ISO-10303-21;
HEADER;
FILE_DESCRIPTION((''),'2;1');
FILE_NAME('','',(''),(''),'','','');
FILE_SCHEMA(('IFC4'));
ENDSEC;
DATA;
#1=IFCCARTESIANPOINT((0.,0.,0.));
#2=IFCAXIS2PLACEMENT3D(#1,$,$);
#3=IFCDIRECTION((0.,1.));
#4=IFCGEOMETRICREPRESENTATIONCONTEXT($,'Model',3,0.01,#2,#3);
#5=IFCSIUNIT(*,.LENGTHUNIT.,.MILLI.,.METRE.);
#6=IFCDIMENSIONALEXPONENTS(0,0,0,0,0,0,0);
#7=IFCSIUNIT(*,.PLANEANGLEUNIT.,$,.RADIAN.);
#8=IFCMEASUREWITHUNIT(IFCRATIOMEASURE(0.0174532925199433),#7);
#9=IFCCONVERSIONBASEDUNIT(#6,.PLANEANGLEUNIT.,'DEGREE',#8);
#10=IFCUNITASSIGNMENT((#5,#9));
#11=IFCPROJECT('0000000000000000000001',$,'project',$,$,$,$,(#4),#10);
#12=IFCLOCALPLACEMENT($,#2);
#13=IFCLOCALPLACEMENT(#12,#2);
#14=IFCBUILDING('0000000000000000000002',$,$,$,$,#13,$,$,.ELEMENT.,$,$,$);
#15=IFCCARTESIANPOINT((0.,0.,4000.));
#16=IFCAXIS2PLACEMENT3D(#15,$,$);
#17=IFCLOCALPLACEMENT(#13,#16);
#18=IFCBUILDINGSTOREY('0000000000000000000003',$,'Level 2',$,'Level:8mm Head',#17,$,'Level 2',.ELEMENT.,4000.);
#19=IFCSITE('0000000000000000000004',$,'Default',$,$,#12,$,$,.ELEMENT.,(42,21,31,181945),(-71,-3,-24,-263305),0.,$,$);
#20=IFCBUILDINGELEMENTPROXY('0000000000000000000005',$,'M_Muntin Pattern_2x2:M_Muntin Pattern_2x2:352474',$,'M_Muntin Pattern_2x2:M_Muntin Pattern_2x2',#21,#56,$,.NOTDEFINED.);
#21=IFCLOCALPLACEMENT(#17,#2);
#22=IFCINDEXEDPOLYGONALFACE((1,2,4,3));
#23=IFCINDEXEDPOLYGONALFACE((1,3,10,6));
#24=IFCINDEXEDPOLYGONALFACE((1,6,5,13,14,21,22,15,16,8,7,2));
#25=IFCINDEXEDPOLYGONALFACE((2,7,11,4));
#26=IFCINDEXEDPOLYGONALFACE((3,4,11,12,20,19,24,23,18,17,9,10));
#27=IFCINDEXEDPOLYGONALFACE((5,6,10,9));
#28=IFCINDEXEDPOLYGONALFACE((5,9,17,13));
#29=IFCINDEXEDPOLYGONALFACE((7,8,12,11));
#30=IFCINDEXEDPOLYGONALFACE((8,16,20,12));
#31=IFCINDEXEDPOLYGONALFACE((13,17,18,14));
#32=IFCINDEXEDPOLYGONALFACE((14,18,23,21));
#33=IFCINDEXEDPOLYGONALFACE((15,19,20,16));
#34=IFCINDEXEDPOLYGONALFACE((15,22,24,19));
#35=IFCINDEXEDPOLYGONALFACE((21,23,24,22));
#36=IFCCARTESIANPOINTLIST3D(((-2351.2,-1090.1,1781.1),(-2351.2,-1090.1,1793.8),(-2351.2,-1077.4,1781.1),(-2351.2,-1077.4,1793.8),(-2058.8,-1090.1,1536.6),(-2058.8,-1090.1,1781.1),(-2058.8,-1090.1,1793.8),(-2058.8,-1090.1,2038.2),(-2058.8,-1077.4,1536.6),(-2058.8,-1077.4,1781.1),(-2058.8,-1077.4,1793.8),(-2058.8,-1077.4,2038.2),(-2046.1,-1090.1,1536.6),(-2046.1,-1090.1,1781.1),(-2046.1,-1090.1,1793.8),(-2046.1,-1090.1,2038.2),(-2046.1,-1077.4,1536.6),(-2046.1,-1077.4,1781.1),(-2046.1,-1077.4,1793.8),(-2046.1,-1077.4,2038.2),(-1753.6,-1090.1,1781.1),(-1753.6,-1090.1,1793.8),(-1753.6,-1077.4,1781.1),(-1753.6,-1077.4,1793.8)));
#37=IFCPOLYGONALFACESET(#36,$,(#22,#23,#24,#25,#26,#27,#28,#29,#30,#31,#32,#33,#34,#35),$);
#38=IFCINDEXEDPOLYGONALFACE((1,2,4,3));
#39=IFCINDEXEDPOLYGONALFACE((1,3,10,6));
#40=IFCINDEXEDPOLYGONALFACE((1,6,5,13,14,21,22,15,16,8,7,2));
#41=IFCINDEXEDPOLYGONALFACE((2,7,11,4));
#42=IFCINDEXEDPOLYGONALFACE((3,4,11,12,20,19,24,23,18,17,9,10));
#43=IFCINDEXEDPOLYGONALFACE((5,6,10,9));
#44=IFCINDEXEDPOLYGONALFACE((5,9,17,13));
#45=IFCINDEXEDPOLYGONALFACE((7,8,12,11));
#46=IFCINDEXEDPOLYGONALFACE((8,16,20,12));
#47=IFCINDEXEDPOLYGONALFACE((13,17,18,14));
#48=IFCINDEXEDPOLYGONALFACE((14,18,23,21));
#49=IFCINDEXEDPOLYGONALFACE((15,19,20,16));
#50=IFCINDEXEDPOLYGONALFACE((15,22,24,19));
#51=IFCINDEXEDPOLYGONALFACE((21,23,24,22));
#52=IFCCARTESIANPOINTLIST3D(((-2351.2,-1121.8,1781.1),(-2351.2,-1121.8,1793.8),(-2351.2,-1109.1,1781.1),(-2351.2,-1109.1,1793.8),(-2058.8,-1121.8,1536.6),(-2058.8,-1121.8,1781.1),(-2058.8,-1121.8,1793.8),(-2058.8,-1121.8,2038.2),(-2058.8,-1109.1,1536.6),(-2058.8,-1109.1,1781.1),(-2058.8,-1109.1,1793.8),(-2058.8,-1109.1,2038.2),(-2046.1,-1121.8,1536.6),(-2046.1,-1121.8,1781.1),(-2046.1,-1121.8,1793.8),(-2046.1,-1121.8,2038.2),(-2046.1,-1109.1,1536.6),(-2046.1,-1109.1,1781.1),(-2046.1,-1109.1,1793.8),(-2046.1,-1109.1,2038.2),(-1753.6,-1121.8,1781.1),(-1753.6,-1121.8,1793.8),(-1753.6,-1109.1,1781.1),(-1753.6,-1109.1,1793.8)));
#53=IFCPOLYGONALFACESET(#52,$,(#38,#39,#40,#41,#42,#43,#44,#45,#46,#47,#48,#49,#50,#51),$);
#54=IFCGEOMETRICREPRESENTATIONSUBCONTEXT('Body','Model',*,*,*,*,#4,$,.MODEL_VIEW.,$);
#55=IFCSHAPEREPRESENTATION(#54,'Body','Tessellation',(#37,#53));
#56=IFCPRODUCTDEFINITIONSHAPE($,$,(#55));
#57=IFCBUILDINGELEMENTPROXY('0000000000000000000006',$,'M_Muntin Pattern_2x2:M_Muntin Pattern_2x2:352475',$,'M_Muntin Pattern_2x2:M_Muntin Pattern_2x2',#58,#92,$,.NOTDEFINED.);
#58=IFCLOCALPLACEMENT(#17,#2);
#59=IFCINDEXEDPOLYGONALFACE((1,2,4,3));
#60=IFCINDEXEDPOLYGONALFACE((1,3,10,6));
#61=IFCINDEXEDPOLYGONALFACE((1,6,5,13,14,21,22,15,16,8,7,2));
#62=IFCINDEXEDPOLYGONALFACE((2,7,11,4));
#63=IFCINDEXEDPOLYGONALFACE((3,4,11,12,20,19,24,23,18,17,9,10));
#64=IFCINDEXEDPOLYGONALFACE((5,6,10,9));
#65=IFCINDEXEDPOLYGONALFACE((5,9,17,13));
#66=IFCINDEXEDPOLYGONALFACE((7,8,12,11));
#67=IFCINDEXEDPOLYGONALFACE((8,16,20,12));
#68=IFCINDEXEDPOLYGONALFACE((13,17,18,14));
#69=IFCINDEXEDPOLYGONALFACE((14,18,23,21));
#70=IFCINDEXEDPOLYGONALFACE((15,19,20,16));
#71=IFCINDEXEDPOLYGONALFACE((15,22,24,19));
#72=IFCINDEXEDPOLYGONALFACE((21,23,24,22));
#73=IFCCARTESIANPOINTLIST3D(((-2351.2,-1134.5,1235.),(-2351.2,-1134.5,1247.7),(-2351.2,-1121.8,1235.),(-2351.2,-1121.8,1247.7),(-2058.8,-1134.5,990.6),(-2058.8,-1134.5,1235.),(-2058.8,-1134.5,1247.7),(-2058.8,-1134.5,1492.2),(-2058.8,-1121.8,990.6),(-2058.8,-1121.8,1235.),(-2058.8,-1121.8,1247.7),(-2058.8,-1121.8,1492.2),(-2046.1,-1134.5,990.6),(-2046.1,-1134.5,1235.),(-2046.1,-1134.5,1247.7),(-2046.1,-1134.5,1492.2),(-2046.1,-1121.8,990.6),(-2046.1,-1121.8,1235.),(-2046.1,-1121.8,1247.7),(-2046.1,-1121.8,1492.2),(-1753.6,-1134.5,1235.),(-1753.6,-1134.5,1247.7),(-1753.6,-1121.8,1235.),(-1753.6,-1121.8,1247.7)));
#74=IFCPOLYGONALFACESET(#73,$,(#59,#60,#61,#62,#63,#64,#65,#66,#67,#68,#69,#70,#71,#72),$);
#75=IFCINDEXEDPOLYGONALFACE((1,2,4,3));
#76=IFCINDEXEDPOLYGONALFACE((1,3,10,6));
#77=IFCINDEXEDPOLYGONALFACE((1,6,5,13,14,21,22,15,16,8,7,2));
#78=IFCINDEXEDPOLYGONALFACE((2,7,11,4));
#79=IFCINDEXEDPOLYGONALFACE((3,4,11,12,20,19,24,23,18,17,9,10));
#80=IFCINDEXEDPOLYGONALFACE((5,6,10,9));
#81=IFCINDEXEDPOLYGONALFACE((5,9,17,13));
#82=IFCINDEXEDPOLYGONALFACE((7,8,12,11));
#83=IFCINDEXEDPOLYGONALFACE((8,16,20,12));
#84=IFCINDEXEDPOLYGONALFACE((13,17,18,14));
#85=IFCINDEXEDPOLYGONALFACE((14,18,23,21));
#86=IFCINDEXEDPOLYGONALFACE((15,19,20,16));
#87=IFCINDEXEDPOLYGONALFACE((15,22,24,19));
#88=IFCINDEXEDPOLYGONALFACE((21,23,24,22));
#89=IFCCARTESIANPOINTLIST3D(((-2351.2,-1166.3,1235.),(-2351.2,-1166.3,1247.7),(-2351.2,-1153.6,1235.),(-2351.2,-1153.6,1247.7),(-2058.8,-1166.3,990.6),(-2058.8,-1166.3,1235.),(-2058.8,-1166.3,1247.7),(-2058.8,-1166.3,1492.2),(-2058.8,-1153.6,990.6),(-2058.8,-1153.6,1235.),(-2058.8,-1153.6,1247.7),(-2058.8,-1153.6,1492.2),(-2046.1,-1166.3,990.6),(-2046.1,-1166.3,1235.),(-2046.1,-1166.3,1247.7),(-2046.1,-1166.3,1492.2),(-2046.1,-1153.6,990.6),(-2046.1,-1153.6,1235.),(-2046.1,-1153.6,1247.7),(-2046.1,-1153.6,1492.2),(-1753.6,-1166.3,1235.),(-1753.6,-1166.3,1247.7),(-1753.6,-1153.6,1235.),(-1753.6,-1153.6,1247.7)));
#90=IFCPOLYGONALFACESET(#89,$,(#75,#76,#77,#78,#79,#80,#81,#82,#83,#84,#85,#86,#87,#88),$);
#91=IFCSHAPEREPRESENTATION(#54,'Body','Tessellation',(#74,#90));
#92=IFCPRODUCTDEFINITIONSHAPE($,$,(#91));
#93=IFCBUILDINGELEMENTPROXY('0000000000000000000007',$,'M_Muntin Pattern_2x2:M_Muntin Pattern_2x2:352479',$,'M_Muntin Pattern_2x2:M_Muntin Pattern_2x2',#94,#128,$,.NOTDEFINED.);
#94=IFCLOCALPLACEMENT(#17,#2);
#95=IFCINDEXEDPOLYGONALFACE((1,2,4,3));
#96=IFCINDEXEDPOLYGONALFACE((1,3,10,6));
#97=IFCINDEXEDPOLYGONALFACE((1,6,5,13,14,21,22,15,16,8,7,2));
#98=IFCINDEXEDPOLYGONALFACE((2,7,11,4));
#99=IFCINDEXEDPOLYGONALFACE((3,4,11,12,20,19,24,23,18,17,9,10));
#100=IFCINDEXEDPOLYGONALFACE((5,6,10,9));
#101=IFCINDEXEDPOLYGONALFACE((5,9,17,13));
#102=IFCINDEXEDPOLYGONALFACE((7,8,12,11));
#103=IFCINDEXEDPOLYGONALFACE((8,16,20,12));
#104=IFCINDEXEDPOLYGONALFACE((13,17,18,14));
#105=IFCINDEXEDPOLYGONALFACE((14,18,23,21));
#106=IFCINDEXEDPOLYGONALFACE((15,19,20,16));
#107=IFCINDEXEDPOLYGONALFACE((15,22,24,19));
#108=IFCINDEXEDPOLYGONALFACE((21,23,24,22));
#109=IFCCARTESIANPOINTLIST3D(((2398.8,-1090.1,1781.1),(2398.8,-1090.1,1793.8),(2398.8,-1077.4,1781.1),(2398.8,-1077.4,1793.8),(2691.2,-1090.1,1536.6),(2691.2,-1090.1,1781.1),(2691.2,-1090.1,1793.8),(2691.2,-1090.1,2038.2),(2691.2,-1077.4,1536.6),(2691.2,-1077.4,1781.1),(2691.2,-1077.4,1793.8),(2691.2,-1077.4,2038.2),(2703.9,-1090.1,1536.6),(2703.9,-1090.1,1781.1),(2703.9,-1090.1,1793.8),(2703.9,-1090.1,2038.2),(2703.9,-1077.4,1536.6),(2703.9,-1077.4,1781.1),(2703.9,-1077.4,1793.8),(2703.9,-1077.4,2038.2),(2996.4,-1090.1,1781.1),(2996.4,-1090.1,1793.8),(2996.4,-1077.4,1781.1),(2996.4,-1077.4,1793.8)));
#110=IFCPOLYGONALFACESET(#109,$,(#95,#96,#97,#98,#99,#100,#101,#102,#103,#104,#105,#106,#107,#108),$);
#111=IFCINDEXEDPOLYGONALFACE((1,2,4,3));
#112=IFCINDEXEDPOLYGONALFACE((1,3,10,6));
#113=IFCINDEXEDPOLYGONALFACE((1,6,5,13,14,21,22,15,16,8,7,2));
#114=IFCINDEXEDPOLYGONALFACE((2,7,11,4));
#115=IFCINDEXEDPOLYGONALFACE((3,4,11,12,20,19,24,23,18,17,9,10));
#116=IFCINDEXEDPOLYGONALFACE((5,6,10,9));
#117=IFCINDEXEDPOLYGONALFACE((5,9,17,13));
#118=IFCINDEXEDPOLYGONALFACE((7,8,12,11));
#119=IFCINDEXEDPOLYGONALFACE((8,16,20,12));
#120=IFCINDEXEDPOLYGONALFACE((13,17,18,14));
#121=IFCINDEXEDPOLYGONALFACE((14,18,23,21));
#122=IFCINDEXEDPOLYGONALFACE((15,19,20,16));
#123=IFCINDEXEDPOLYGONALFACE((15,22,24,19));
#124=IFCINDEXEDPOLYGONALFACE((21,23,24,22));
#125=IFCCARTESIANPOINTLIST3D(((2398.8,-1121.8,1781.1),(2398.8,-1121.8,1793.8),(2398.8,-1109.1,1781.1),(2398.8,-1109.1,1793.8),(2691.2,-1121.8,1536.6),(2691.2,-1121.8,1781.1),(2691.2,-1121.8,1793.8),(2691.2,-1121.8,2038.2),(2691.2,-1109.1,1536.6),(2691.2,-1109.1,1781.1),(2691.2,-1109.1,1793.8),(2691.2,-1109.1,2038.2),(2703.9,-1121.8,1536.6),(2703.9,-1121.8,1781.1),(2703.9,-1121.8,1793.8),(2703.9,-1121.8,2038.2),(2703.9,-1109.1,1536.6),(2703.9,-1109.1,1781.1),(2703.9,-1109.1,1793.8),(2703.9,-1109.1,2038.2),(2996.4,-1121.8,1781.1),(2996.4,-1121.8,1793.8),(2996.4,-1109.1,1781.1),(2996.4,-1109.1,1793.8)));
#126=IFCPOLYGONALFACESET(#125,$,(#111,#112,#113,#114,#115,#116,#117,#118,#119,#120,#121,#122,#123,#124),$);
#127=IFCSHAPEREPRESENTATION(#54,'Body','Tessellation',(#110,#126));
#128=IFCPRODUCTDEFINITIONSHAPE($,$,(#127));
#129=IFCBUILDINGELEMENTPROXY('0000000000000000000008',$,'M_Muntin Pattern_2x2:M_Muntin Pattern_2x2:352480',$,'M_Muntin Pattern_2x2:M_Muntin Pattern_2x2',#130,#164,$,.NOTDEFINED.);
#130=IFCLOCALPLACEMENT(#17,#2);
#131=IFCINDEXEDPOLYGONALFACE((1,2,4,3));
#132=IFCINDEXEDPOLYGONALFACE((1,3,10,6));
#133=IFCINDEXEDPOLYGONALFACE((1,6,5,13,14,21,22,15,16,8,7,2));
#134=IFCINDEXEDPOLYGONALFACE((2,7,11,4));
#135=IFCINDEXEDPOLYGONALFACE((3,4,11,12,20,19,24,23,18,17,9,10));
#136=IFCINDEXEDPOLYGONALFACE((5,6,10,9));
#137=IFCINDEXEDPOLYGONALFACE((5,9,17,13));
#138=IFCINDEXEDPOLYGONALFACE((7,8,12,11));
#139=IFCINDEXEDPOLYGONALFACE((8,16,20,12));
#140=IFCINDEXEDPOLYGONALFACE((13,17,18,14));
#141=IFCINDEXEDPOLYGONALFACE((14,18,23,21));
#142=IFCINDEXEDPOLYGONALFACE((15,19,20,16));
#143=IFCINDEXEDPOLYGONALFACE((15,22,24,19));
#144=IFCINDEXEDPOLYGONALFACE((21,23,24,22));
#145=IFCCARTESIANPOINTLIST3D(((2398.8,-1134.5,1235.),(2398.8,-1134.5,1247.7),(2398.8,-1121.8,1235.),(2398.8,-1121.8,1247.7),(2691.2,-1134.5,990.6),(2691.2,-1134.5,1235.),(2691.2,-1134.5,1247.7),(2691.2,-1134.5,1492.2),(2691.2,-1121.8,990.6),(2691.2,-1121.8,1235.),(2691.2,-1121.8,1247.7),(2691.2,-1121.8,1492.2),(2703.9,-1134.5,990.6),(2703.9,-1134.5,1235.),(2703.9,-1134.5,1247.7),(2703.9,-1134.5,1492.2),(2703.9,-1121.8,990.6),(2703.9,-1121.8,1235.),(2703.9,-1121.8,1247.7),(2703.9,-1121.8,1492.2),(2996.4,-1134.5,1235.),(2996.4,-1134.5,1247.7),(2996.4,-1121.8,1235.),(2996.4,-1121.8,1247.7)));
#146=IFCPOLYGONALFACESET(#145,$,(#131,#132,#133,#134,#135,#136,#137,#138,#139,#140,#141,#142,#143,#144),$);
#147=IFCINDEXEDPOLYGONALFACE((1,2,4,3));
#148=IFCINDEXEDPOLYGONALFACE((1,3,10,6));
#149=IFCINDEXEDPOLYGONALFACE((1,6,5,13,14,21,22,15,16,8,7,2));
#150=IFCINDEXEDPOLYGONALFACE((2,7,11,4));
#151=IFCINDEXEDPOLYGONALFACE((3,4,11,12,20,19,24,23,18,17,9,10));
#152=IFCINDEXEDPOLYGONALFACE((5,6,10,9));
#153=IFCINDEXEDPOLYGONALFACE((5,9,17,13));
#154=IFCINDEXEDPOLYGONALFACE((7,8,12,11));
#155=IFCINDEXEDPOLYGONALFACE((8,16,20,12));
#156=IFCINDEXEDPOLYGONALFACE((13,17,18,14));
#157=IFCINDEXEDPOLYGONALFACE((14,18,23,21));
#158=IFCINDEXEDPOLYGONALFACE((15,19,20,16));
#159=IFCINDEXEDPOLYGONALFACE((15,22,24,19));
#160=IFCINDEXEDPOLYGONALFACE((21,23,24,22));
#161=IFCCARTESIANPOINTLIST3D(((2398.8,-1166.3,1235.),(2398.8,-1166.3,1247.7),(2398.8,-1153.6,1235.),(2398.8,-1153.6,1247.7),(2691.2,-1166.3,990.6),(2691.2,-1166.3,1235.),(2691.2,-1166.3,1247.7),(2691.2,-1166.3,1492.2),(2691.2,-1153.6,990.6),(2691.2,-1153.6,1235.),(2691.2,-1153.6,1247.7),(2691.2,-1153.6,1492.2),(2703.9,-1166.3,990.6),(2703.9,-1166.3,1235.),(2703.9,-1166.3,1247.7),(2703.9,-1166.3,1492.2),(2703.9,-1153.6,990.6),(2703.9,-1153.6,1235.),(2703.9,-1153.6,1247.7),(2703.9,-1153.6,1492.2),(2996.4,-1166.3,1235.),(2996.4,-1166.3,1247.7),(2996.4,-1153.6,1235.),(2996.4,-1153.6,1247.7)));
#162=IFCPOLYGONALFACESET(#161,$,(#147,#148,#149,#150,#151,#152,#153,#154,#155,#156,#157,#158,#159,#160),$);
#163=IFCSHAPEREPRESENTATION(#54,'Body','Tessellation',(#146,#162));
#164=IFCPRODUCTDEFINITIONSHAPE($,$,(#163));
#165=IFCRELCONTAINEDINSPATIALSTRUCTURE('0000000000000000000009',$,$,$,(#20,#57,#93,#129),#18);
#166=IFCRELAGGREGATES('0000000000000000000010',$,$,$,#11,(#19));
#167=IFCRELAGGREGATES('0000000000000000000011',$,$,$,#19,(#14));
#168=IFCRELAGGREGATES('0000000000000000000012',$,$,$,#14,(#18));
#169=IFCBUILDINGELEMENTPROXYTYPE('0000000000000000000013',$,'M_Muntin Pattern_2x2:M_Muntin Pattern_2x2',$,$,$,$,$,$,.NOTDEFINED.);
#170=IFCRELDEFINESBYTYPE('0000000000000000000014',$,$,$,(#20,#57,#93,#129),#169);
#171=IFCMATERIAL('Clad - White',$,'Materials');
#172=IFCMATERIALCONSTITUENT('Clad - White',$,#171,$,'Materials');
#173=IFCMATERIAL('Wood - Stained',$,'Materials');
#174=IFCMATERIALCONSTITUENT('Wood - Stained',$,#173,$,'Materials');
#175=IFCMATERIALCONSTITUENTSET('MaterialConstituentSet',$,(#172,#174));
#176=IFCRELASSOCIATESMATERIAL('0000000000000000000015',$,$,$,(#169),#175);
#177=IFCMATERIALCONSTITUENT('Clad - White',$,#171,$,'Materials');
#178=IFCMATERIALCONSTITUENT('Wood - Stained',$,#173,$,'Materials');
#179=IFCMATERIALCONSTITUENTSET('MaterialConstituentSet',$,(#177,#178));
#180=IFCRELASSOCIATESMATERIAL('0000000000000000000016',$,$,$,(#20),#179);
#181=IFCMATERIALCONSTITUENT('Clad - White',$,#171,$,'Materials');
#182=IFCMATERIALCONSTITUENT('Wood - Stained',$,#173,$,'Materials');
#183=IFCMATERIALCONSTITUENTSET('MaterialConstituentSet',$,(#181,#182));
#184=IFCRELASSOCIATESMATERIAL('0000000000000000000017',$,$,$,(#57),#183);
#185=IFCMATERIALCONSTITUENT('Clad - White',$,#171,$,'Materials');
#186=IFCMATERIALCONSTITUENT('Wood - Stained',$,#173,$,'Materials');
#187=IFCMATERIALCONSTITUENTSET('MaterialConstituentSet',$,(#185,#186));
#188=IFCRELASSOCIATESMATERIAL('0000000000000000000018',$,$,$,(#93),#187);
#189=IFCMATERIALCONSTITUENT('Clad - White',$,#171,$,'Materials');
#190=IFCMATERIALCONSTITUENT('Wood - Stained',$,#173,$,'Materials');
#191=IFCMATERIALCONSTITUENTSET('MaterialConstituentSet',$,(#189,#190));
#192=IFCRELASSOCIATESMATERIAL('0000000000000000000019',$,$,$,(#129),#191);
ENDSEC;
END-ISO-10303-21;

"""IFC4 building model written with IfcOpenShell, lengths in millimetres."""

from ifc_helpers import new_model, entity, si_unit, converted_unit, direction, frame, origin, place, context, subcontext, project, spatial, polyline, outline, extrude, source, transform, mapped, material, constituent, constituent_set, type_object, type_shapes, element, save


model = new_model("IFC4")

# Units and contexts
model_context = context("Model", 3, precision=0.01, world=origin(), true_north=direction((0.0, 1.0)))
body_context = subcontext(model_context, "Body", "Model", "MODEL_VIEW")
ifc_project = project(units=[si_unit("LENGTHUNIT", "METRE", prefix="MILLI"), converted_unit("PLANEANGLEUNIT", "DEGREE", entity("IfcRatioMeasure", 0.0174532925199433), si_unit("PLANEANGLEUNIT", "RADIAN"), dimensions=[0, 0, 0, 0, 0, 0, 0])], contexts=[model_context])

# Site, building, storey
site_placement = place(None, origin())
site = spatial("IfcSite", under=ifc_project, at=site_placement, Name="Default", CompositionType="ELEMENT", RefLatitude=(42, 21, 31, 181945), RefLongitude=(-71, -3, -24, -263305), RefElevation=0.0)
building_placement = place(site_placement, origin())
building = spatial("IfcBuilding", under=site, at=building_placement, CompositionType="ELEMENT")
storey_placement = place(building_placement, frame((0.0, 0.0, 4000.0)))
storey = spatial("IfcBuildingStorey", under=building, at=storey_placement, Name="Level 2", ObjectType="Level:8mm Head", LongName="Level 2", CompositionType="ELEMENT", Elevation=4000.0)

# Shared definitions
ifc_material_1 = material(Name="Wood - Stained", Category="Materials")

# Building element proxies
ifc_material_2 = material(Name="Clad - White", Category="Materials")
ifc_constituent_1 = constituent(ifc_material_2, Name="Clad - White", Category="Materials")
ifc_constituent_2 = constituent(ifc_material_1, Name="Wood - Stained", Category="Materials")
ifc_constituent_set_1 = constituent_set(constituents=[ifc_constituent_1, ifc_constituent_2], Name="MaterialConstituentSet")
ifc_constituent_3 = constituent(ifc_material_2, Name="Clad - White", Category="Materials")
ifc_constituent_4 = constituent(ifc_material_1, Name="Wood - Stained", Category="Materials")
ifc_constituent_set_2 = constituent_set(constituents=[ifc_constituent_3, ifc_constituent_4], Name="MaterialConstituentSet")
building_element_proxy_type_1 = type_object("IfcBuildingElementProxyType", Name="M_Muntin Pattern_2x2:M_Muntin Pattern_2x2", PredefinedType="NOTDEFINED", material=ifc_constituent_set_2)
shared_shape_1 = source(origin(), body_context, "Body", "SweptSolid", [
    extrude(outline(polyline([(6.4, -6.4), (250.8, -6.4), (250.8, 6.3), (6.4, 6.3), (6.4, 298.8), (-6.3, 298.8), (-6.3, 6.3), (-250.8, 6.3), (-250.8, -6.4), (-6.3, -6.4), (-6.3, -298.8), (6.4, -298.8), (6.4, -6.4)])), frame((0.0, 9.5, 250.8), z_axis=(0.0, 1.0, 0.0), x_axis=(0.0, 0.0, 1.0)), (0.0, 0.0, 1.0), 12.7),
    extrude(outline(polyline([(6.4, -6.4), (250.8, -6.4), (250.8, 6.3), (6.4, 6.3), (6.4, 298.8), (-6.3, 298.8), (-6.3, 6.3), (-250.8, 6.3), (-250.8, -6.4), (-6.3, -6.4), (-6.3, -298.8), (6.4, -298.8), (6.4, -6.4)])), frame((0.0, -22.2, 250.8), z_axis=(0.0, 1.0, 0.0), x_axis=(0.0, 0.0, 1.0)), (0.0, 0.0, 1.0), 12.7),
])
type_shapes(building_element_proxy_type_1, [shared_shape_1])
proxy_1_placement = place(storey_placement, frame((-2052.4, -1099.6, 1536.6)))
element("IfcBuildingElementProxy", 1, at=proxy_1_placement, inside=storey, type_object=building_element_proxy_type_1, material=ifc_constituent_set_1, Name="M_Muntin Pattern_2x2:M_Muntin Pattern_2x2:352474", ObjectType="M_Muntin Pattern_2x2:M_Muntin Pattern_2x2", PredefinedType="NOTDEFINED", context=body_context, shape_type="MappedRepresentation", body=[
    mapped(shared_shape_1, transform((0.0, 0.0, 0.0), scale=1.0)),
])
ifc_constituent_5 = constituent(ifc_material_2, Name="Clad - White", Category="Materials")
ifc_constituent_6 = constituent(ifc_material_1, Name="Wood - Stained", Category="Materials")
ifc_constituent_set_3 = constituent_set(constituents=[ifc_constituent_5, ifc_constituent_6], Name="MaterialConstituentSet")
proxy_2_placement = place(storey_placement, frame((-2052.4, -1144.0, 990.6)))
element("IfcBuildingElementProxy", 2, at=proxy_2_placement, inside=storey, type_object=building_element_proxy_type_1, material=ifc_constituent_set_3, Name="M_Muntin Pattern_2x2:M_Muntin Pattern_2x2:352475", ObjectType="M_Muntin Pattern_2x2:M_Muntin Pattern_2x2", PredefinedType="NOTDEFINED", context=body_context, shape_type="MappedRepresentation", body=[
    mapped(shared_shape_1, transform((0.0, 0.0, 0.0), scale=1.0)),
])
ifc_constituent_7 = constituent(ifc_material_2, Name="Clad - White", Category="Materials")
ifc_constituent_8 = constituent(ifc_material_1, Name="Wood - Stained", Category="Materials")
ifc_constituent_set_4 = constituent_set(constituents=[ifc_constituent_7, ifc_constituent_8], Name="MaterialConstituentSet")
proxy_3_placement = place(storey_placement, frame((2697.6, -1099.6, 1536.6)))
element("IfcBuildingElementProxy", 3, at=proxy_3_placement, inside=storey, type_object=building_element_proxy_type_1, material=ifc_constituent_set_4, Name="M_Muntin Pattern_2x2:M_Muntin Pattern_2x2:352479", ObjectType="M_Muntin Pattern_2x2:M_Muntin Pattern_2x2", PredefinedType="NOTDEFINED", context=body_context, shape_type="MappedRepresentation", body=[
    mapped(shared_shape_1, transform((0.0, 0.0, 0.0), scale=1.0)),
])
ifc_constituent_9 = constituent(ifc_material_2, Name="Clad - White", Category="Materials")
ifc_constituent_10 = constituent(ifc_material_1, Name="Wood - Stained", Category="Materials")
ifc_constituent_set_5 = constituent_set(constituents=[ifc_constituent_9, ifc_constituent_10], Name="MaterialConstituentSet")
proxy_4_placement = place(storey_placement, frame((2697.6, -1144.0, 990.6)))
element("IfcBuildingElementProxy", 4, at=proxy_4_placement, inside=storey, type_object=building_element_proxy_type_1, material=ifc_constituent_set_5, Name="M_Muntin Pattern_2x2:M_Muntin Pattern_2x2:352480", ObjectType="M_Muntin Pattern_2x2:M_Muntin Pattern_2x2", PredefinedType="NOTDEFINED", context=body_context, shape_type="MappedRepresentation", body=[
    mapped(shared_shape_1, transform((0.0, 0.0, 0.0), scale=1.0)),
])

save(model, "model.ifc")
